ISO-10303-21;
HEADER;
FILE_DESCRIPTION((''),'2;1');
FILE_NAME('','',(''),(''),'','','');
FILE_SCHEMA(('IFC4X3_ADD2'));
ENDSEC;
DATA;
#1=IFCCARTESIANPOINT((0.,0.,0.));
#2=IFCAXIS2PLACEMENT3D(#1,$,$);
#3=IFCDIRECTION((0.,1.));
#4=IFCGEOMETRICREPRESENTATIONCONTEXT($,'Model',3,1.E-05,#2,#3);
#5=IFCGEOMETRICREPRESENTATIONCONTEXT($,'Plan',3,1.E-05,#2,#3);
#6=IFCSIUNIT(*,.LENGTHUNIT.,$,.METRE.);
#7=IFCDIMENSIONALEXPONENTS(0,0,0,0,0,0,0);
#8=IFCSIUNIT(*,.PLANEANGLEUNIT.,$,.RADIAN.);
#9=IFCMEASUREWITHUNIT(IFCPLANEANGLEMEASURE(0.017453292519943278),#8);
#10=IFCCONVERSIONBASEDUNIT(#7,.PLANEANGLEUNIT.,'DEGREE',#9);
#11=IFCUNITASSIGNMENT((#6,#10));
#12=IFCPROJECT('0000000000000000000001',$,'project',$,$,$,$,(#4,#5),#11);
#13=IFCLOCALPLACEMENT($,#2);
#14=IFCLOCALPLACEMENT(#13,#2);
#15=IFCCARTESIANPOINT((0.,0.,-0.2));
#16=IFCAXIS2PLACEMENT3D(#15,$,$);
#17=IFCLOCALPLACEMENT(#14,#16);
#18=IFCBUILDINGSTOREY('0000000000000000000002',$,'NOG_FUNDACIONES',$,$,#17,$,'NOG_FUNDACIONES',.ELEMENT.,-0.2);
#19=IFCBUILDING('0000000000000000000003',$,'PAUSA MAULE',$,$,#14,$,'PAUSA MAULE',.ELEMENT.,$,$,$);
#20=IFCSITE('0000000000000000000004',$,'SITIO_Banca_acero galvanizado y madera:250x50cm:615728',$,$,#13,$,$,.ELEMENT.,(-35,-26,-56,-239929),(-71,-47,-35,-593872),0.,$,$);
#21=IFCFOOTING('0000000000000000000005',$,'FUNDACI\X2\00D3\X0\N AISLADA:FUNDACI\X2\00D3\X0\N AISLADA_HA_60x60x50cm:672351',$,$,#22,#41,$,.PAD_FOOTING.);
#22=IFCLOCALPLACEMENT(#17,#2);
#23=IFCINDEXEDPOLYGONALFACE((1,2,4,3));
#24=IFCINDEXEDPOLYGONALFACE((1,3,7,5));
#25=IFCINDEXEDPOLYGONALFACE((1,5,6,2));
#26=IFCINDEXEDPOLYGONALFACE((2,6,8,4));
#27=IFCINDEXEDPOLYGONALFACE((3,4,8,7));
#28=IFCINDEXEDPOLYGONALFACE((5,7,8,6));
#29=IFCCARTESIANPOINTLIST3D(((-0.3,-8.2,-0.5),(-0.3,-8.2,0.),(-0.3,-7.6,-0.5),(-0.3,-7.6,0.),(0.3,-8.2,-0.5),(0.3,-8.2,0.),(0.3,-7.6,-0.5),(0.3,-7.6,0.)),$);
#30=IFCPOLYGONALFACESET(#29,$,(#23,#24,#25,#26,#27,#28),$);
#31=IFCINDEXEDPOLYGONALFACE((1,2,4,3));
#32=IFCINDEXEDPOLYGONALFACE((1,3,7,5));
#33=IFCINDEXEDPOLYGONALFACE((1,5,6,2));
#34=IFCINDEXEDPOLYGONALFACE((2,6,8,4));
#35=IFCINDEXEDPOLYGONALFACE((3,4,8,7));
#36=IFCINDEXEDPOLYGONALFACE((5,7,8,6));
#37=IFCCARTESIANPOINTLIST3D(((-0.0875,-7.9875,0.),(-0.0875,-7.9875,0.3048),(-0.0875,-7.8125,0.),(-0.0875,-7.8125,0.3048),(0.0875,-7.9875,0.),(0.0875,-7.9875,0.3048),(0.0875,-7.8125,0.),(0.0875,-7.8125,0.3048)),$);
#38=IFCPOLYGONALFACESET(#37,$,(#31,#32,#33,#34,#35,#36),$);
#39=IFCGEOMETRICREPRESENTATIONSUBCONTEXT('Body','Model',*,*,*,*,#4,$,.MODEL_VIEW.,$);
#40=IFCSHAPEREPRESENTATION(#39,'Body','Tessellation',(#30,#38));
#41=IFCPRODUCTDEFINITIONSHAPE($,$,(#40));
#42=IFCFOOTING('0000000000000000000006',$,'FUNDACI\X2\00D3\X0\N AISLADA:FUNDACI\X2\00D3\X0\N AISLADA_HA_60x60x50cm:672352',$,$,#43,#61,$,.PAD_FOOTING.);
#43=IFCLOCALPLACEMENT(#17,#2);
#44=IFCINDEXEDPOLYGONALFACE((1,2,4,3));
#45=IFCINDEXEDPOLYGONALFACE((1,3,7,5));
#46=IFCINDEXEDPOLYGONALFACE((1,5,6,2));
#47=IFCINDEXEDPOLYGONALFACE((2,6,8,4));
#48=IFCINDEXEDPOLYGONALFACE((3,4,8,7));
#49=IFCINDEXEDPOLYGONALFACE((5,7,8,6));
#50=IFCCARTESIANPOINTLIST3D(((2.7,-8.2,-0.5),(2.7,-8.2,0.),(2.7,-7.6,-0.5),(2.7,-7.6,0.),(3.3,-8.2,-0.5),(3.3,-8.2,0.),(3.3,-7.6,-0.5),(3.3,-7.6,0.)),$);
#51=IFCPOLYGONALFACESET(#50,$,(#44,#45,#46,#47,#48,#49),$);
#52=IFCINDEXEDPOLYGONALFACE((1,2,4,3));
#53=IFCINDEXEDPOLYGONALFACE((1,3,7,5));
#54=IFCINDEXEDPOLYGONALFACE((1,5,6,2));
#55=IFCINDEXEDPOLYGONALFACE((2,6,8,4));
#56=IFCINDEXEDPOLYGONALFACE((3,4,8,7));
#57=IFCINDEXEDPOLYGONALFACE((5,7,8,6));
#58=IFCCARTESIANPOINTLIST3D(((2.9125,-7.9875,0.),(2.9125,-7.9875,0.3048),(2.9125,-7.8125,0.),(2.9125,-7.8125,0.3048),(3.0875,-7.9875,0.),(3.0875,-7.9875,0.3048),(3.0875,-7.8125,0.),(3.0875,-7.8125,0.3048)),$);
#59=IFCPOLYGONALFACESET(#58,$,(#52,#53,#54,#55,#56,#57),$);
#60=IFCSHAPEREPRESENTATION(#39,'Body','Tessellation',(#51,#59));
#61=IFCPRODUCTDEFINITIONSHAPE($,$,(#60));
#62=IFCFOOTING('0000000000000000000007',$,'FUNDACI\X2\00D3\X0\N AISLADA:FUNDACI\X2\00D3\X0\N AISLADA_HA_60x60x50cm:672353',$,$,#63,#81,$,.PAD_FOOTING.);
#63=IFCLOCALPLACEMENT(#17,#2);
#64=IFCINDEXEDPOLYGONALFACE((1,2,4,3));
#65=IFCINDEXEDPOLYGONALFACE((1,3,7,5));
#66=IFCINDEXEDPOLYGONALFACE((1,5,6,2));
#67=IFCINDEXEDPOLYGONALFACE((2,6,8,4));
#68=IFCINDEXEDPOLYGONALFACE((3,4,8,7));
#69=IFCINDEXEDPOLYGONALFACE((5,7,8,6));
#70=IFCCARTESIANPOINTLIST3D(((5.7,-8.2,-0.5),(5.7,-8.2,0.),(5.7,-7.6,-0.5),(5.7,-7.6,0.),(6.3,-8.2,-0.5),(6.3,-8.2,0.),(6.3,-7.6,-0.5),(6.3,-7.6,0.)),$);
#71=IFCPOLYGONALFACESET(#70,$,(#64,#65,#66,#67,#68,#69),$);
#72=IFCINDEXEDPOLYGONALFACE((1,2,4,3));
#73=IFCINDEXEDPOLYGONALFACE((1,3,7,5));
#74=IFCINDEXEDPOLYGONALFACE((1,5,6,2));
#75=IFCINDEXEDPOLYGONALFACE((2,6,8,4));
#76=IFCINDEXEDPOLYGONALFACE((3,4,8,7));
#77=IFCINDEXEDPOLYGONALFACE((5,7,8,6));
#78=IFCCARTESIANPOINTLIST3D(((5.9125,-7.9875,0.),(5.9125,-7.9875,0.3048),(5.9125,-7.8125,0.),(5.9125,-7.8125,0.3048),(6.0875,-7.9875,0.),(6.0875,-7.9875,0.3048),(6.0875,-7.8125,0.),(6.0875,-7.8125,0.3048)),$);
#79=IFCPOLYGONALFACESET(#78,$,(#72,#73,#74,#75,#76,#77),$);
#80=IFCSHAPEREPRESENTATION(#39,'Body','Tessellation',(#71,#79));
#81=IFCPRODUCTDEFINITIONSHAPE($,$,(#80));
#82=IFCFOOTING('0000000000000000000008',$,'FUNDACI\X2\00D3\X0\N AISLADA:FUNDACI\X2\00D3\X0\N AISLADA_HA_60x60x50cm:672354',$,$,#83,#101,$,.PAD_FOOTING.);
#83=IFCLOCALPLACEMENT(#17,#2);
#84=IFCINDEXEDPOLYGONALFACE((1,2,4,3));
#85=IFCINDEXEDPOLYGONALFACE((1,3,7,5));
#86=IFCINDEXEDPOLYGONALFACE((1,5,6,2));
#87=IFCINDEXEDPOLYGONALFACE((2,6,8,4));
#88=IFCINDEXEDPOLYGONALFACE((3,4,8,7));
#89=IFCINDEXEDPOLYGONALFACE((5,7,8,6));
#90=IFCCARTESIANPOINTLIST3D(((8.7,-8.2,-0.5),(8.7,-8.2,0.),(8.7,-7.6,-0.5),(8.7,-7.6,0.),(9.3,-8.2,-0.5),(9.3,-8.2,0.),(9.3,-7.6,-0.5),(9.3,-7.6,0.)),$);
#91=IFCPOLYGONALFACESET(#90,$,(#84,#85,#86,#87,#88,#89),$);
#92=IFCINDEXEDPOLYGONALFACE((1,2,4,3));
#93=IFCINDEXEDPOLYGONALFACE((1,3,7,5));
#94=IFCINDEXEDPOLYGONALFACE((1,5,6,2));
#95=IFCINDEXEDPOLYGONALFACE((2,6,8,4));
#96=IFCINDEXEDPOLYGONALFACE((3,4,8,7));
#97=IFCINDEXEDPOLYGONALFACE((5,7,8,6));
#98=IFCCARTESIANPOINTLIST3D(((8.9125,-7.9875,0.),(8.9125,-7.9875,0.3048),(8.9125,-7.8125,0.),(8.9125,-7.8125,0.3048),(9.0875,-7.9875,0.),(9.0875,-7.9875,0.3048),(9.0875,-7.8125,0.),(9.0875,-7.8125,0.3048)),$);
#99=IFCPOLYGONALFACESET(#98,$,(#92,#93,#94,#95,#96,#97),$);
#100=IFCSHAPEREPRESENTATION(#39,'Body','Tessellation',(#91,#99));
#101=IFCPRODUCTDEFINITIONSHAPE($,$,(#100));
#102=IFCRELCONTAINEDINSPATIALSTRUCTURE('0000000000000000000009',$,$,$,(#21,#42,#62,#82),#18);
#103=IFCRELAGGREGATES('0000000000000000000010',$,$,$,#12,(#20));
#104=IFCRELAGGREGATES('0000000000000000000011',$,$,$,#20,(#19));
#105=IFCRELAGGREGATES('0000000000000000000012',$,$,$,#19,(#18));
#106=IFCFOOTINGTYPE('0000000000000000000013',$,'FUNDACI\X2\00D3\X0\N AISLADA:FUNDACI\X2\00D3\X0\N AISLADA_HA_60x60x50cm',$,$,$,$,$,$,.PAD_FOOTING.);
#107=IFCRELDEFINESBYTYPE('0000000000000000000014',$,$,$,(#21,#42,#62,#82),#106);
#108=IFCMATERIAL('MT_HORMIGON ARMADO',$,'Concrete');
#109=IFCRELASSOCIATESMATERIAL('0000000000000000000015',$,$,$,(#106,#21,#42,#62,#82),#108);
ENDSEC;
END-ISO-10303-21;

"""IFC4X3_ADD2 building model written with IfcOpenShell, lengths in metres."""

from ifc_helpers import new_model, entity, si_unit, converted_unit, direction, frame, origin, origin_2d_with_axis, place, context, subcontext, project, spatial, rectangle, extrude, source, transform, mapped, material, type_object, type_shapes, element, save


model = new_model("IFC4X3_ADD2")

# Units and contexts
model_context = context("Model", 3, precision=1e-05, world=origin(), true_north=direction((0.0, 1.0)))
plan_context = context("Plan", 3, precision=1e-05, world=origin(), true_north=direction((0.0, 1.0)))
body_context = subcontext(model_context, "Body", "Model", "MODEL_VIEW")
ifc_project = project(units=[si_unit("LENGTHUNIT", "METRE"), converted_unit("PLANEANGLEUNIT", "DEGREE", entity("IfcPlaneAngleMeasure", 0.017453292519943278), si_unit("PLANEANGLEUNIT", "RADIAN"), dimensions=[0, 0, 0, 0, 0, 0, 0])], contexts=[model_context, plan_context])

# Site, building, storey
site_placement = place(None, origin())
site = spatial("IfcSite", under=ifc_project, at=site_placement, Name="SITIO_Banca_acero galvanizado y madera:250x50cm:615728", CompositionType="ELEMENT", RefLatitude=(-35, -26, -56, -239929), RefLongitude=(-71, -47, -35, -593872), RefElevation=0.0)
building_placement = place(site_placement, origin())
building = spatial("IfcBuilding", under=site, at=building_placement, Name="PAUSA MAULE", LongName="PAUSA MAULE", CompositionType="ELEMENT")
storey_placement = place(building_placement, frame((0.0, 0.0, -0.2)))
storey = spatial("IfcBuildingStorey", under=building, at=storey_placement, Name="NOG_FUNDACIONES", LongName="NOG_FUNDACIONES", CompositionType="ELEMENT", Elevation=-0.2)

# Footings
ifc_material = material(Name="MT_HORMIGON ARMADO", Category="Concrete")
footing_type = type_object("IfcFootingType", Name="FUNDACIÓN AISLADA:FUNDACIÓN AISLADA_HA_60x60x50cm", PredefinedType="PAD_FOOTING", material=ifc_material)
shared_shape = source(origin(), body_context, "Body", "SweptSolid", [
    extrude(rectangle(XDim=0.6, YDim=0.6, at=origin_2d_with_axis()), frame((0.0, 0.0, -0.5), z_axis=(0.0, 0.0, 1.0), x_axis=(-1.0, 0.0, 0.0)), (0.0, 0.0, 1.0), 0.5),
    extrude(rectangle(XDim=0.175, YDim=0.175, at=origin_2d_with_axis()), frame((0.0, 0.0, 0.0), z_axis=(0.0, 0.0, 1.0), x_axis=(-1.0, 0.0, 0.0)), (0.0, 0.0, 1.0), 0.3048),
])
type_shapes(footing_type, [shared_shape])
for number, where, name in (
    (1, (0.0, -7.9, 0.0), "FUNDACIÓN AISLADA:FUNDACIÓN AISLADA_HA_60x60x50cm:672351"),
    (2, (3.0, -7.9, 0.0), "FUNDACIÓN AISLADA:FUNDACIÓN AISLADA_HA_60x60x50cm:672352"),
    (3, (6.0, -7.9, 0.0), "FUNDACIÓN AISLADA:FUNDACIÓN AISLADA_HA_60x60x50cm:672353"),
    (4, (9.0, -7.9, 0.0), "FUNDACIÓN AISLADA:FUNDACIÓN AISLADA_HA_60x60x50cm:672354"),
):
    element("IfcFooting", number, at=place(storey_placement, frame(where)), inside=storey, type_object=footing_type, material=ifc_material, Name=name, PredefinedType="PAD_FOOTING", context=body_context, shape_type="MappedRepresentation", body=[
        mapped(shared_shape, transform((0.0, 0.0, 0.0), scale=1.0)),
    ])

save(model, "model.ifc")
